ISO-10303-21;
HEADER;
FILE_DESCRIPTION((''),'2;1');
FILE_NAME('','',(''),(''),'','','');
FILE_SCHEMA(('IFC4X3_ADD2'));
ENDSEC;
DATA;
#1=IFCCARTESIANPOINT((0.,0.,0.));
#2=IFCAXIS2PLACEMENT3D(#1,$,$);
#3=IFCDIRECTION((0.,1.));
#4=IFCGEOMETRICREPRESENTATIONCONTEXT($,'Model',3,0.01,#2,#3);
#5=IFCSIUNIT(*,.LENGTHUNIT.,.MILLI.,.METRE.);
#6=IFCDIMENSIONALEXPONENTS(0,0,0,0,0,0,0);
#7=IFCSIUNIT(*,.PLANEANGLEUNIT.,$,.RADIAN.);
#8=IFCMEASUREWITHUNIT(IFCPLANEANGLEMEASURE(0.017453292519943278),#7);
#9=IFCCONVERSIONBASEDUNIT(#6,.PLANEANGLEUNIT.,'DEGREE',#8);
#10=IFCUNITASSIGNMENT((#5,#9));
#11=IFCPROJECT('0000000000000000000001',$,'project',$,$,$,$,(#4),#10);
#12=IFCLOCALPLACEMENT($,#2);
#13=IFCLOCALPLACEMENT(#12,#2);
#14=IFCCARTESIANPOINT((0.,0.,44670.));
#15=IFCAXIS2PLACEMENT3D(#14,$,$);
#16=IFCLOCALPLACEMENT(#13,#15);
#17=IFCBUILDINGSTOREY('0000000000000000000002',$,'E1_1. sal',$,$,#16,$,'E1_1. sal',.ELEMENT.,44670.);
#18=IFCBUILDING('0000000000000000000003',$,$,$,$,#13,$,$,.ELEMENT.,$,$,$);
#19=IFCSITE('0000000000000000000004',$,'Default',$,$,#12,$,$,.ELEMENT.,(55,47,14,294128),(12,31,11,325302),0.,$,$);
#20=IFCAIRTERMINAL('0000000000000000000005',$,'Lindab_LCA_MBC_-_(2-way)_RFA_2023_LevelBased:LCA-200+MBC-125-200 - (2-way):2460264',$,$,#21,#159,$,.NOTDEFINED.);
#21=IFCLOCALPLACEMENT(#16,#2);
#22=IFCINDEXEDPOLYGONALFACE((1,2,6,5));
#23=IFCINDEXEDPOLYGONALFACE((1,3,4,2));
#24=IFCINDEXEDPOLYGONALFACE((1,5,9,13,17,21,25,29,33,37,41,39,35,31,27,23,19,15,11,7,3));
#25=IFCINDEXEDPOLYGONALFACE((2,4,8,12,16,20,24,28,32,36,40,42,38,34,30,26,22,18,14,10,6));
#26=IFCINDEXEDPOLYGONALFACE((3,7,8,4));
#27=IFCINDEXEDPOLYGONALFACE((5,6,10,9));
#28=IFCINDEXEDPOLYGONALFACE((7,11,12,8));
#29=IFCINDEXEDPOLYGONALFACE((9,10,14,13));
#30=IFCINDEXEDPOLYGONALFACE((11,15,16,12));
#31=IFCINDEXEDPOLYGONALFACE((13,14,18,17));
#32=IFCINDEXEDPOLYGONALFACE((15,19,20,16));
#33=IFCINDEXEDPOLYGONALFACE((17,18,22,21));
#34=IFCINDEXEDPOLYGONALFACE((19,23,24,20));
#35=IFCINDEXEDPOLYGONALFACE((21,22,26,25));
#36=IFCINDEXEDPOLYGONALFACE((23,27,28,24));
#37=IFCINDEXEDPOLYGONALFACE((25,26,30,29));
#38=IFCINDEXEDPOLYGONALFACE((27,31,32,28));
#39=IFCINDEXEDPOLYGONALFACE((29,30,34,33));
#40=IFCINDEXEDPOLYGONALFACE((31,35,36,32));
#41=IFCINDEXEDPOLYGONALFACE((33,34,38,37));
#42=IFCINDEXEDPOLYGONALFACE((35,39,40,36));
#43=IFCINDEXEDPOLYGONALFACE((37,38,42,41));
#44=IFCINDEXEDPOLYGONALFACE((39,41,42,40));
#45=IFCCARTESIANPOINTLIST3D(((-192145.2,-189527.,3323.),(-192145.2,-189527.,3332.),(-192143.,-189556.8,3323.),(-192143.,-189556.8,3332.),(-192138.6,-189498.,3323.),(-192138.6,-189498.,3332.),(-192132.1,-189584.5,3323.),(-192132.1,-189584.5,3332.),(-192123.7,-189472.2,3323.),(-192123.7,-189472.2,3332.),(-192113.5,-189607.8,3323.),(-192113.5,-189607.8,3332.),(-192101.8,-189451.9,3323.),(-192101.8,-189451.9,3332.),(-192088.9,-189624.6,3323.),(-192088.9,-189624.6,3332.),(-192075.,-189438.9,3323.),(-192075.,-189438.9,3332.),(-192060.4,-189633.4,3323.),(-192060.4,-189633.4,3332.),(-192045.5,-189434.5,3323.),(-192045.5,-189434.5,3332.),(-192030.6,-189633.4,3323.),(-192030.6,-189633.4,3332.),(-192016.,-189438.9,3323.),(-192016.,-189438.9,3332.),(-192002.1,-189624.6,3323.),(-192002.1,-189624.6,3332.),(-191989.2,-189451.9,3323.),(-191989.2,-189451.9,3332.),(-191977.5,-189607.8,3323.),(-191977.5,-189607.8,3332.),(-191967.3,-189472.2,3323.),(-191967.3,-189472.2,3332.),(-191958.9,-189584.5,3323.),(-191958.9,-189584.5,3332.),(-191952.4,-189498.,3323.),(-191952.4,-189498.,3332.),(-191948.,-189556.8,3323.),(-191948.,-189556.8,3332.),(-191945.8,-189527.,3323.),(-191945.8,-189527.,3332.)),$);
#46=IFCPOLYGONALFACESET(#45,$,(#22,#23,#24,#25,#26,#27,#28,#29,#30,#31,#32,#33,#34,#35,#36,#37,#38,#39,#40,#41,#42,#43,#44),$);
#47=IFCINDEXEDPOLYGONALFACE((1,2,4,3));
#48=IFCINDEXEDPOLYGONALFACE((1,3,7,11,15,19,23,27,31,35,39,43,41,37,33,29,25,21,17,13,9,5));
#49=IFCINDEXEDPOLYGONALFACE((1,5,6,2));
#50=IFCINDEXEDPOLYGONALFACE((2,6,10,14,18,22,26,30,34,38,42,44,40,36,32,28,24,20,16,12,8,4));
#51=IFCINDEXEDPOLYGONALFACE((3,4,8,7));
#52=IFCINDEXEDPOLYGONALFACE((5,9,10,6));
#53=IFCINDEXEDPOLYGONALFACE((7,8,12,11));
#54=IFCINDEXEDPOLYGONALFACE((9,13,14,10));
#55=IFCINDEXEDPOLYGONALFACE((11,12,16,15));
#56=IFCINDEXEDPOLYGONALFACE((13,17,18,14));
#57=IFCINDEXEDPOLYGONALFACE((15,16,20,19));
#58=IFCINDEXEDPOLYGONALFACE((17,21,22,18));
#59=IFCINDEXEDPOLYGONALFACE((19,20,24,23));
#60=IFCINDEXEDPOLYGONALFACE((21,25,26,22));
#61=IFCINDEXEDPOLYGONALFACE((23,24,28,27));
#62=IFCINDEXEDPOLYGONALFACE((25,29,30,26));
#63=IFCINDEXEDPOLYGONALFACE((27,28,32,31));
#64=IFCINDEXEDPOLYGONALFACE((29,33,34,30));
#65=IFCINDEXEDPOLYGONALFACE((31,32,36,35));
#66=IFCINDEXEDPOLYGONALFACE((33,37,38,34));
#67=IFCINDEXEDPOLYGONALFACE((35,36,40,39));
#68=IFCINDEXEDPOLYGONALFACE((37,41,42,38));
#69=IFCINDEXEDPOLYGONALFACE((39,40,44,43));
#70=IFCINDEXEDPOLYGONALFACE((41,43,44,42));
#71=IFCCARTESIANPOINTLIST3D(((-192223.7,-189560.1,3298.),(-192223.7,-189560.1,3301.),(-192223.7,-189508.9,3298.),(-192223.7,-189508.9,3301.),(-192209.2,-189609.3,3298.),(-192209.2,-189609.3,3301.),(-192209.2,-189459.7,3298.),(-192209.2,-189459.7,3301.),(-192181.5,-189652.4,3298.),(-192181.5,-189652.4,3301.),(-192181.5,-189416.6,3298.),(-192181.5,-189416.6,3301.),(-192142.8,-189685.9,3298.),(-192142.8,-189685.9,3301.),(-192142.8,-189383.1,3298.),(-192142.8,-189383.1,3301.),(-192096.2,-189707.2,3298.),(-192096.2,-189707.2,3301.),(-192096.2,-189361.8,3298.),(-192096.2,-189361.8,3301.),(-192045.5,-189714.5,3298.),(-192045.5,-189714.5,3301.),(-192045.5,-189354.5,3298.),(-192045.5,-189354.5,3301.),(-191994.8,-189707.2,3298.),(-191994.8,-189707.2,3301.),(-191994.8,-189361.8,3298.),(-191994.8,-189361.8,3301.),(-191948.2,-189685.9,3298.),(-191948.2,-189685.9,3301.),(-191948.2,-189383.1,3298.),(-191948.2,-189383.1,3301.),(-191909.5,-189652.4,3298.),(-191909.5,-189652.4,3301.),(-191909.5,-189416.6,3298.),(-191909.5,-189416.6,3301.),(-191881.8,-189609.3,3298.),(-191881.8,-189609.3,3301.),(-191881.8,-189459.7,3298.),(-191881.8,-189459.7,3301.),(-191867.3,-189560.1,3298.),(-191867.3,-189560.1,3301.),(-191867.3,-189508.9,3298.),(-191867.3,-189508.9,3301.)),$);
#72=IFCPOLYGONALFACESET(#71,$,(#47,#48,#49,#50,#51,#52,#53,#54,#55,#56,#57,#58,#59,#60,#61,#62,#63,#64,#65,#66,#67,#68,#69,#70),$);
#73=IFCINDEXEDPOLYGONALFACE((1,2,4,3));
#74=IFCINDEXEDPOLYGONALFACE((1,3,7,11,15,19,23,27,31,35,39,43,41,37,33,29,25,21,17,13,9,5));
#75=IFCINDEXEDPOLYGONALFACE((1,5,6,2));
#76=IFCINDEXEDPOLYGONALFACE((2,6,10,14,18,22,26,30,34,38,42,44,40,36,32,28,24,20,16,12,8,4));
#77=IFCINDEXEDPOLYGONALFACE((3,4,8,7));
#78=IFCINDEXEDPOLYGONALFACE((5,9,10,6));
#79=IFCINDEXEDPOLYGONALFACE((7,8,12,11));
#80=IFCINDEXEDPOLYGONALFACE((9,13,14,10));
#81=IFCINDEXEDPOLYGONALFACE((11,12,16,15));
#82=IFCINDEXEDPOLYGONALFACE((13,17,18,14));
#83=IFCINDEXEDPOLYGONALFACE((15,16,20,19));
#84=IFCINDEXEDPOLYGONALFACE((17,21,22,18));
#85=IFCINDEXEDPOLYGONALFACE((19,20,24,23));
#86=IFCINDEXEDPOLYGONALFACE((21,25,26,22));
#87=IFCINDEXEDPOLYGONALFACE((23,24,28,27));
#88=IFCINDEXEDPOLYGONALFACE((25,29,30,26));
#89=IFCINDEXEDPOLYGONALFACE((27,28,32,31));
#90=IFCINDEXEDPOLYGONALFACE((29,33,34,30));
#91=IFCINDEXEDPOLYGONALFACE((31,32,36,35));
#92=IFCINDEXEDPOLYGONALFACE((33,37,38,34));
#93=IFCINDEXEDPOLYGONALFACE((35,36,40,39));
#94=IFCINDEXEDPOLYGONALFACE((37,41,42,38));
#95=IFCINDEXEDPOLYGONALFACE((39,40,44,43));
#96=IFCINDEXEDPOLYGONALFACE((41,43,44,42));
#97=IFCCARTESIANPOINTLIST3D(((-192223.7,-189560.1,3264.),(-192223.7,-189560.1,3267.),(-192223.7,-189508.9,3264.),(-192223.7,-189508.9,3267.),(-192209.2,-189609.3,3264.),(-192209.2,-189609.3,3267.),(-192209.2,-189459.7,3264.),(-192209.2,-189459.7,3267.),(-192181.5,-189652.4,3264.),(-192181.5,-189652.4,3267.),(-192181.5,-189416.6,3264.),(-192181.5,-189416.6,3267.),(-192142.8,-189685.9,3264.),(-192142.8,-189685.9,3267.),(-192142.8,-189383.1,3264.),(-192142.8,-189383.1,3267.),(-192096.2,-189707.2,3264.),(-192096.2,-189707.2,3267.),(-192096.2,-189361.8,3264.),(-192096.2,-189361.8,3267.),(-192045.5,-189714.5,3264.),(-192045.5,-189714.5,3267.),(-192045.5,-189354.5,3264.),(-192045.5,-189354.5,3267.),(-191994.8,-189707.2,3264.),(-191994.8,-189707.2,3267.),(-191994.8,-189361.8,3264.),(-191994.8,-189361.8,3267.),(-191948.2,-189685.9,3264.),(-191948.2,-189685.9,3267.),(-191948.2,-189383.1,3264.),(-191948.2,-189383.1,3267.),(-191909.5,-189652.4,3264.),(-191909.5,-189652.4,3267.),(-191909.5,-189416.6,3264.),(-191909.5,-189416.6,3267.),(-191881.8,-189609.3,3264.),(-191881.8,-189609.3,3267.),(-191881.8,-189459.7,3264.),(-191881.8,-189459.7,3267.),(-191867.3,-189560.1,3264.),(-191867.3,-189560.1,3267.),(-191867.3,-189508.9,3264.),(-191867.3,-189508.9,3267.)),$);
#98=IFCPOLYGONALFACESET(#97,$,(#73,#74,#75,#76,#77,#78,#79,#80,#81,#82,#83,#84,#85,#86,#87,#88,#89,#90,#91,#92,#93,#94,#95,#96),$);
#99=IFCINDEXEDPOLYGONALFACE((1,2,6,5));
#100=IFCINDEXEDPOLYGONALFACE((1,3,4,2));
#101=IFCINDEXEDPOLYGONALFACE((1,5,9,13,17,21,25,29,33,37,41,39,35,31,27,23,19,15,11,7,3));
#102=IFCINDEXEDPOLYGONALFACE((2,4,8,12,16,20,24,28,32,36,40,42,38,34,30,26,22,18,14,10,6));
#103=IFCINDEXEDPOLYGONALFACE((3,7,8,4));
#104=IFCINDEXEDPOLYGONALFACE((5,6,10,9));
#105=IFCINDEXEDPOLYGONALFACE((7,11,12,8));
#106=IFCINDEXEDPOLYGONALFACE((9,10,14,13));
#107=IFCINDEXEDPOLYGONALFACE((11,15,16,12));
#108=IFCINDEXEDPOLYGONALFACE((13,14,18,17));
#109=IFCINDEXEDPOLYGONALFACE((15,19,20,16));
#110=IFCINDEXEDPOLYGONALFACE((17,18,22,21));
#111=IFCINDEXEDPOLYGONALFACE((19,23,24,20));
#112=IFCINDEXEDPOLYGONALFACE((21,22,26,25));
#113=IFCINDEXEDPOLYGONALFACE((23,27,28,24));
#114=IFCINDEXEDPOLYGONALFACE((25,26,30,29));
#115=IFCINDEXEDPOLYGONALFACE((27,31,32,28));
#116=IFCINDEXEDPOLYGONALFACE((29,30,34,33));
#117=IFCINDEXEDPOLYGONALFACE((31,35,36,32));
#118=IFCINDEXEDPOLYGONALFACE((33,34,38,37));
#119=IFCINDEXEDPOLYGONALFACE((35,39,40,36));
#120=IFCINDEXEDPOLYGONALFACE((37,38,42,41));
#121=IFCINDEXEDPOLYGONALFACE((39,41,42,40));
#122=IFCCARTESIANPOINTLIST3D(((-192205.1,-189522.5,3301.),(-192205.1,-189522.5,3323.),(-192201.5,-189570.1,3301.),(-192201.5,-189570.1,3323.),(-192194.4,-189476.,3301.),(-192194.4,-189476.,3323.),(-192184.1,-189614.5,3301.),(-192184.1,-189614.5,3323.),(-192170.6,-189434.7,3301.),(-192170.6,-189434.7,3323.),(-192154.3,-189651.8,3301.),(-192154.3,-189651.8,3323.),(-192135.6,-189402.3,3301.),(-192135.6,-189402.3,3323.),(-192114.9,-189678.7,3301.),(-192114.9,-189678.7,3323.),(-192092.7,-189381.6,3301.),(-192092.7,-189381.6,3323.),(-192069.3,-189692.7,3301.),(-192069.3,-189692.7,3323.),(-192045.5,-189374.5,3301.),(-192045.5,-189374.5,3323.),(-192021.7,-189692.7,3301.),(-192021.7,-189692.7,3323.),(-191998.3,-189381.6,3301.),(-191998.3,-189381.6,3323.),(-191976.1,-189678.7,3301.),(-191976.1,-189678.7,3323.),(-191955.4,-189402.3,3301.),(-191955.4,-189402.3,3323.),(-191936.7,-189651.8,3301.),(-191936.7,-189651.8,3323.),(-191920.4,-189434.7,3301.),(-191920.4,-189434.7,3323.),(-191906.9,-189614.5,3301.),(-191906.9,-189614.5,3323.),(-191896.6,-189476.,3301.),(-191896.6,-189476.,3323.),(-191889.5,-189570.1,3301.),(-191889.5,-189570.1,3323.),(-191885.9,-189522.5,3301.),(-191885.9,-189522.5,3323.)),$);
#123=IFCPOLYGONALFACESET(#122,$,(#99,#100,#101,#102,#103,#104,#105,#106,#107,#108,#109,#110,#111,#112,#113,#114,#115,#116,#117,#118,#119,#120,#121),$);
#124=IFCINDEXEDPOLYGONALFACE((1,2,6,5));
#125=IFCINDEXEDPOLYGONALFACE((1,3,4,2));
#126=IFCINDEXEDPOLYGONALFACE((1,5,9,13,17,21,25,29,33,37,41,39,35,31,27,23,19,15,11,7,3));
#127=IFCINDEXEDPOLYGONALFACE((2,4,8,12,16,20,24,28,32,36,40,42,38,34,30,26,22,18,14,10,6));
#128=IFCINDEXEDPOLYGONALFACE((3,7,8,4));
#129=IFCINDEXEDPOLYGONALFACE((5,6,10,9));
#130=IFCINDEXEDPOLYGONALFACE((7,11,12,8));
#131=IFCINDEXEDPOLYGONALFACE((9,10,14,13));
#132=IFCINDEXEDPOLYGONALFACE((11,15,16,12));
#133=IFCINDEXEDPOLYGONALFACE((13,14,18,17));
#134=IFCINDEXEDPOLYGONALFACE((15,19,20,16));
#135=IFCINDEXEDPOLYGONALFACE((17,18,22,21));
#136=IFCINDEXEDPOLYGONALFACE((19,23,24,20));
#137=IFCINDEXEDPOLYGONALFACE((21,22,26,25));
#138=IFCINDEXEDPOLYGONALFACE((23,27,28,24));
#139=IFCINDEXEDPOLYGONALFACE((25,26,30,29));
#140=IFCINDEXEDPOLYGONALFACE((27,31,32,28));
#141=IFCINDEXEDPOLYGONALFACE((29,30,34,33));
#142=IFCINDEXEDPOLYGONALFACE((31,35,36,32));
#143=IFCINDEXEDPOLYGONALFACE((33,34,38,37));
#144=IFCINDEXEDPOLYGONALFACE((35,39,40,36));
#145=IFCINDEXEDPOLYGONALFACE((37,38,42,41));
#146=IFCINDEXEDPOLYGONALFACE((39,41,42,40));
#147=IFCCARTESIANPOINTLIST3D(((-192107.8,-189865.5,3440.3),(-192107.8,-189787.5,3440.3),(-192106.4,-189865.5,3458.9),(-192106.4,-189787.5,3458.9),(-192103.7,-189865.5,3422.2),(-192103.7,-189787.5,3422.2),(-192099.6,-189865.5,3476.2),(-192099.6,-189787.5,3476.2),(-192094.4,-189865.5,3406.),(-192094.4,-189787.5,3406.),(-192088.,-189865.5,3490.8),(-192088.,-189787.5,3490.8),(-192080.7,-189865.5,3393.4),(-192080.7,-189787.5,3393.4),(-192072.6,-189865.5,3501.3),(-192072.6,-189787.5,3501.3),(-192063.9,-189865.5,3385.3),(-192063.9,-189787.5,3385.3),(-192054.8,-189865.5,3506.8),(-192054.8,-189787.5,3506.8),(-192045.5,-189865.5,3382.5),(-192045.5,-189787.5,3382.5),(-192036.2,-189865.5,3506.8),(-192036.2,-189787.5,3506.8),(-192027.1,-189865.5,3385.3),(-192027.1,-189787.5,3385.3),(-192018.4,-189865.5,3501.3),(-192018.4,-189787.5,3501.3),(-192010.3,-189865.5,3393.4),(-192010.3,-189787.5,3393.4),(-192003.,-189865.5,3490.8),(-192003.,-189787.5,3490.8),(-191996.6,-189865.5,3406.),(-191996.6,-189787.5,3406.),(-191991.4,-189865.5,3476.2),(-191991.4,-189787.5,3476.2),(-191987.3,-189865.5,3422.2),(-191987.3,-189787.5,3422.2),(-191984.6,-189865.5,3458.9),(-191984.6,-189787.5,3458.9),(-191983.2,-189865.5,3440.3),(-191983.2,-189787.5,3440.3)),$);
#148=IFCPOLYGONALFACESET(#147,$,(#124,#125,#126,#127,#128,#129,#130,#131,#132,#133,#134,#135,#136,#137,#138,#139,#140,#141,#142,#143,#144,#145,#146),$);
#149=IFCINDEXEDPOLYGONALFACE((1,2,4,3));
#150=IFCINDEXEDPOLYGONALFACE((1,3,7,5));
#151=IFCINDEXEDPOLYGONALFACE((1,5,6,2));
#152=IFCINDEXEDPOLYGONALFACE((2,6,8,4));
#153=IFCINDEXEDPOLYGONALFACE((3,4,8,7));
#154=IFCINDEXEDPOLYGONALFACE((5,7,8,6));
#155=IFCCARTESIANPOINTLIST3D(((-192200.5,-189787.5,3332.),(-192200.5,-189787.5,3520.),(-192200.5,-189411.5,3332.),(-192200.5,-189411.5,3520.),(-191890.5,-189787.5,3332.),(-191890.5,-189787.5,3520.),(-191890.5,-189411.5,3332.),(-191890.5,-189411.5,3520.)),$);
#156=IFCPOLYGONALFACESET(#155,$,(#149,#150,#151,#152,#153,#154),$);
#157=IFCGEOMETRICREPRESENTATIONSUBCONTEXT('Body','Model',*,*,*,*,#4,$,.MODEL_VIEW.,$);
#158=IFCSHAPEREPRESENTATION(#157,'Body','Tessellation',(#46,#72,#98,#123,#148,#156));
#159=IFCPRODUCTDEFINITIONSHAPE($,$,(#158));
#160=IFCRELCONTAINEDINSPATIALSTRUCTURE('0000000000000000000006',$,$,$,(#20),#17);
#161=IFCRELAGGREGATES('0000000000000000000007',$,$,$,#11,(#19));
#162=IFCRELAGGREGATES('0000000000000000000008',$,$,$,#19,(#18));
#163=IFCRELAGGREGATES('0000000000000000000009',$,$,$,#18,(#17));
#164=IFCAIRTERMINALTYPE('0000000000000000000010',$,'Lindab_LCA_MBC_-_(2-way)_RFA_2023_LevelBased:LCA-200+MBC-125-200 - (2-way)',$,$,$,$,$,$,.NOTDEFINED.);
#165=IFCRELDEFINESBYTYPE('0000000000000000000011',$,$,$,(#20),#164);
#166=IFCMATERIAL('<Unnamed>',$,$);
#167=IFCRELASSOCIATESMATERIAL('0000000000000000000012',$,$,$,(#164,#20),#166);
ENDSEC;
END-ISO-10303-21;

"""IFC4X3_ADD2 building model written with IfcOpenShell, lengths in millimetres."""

from ifc_helpers import new_model, entity, si_unit, converted_unit, direction, frame, frame_2d, origin, origin_2d_with_axis, place, context, subcontext, project, spatial, rectangle, circle, extrude, source, transform, mapped, material, type_object, type_shapes, element, save


model = new_model("IFC4X3_ADD2")

# Units and contexts
model_context = context("Model", 3, precision=0.01, world=origin(), true_north=direction((0.0, 1.0)))
body_context = subcontext(model_context, "Body", "Model", "MODEL_VIEW")
ifc_project = project(units=[si_unit("LENGTHUNIT", "METRE", prefix="MILLI"), converted_unit("PLANEANGLEUNIT", "DEGREE", entity("IfcPlaneAngleMeasure", 0.017453292519943278), si_unit("PLANEANGLEUNIT", "RADIAN"), dimensions=[0, 0, 0, 0, 0, 0, 0])], contexts=[model_context])

# Site, building, storey
site_placement = place(None, origin())
site = spatial("IfcSite", under=ifc_project, at=site_placement, Name="Default", CompositionType="ELEMENT", RefLatitude=(55, 47, 14, 294128), RefLongitude=(12, 31, 11, 325302), RefElevation=0.0)
building_placement = place(site_placement, origin())
building = spatial("IfcBuilding", under=site, at=building_placement, CompositionType="ELEMENT")
storey_placement = place(building_placement, frame((0.0, 0.0, 44670.0)))
storey = spatial("IfcBuildingStorey", under=building, at=storey_placement, Name="E1_1. sal", LongName="E1_1. sal", CompositionType="ELEMENT", Elevation=44670.0)

# Air terminal
ifc_material_1 = material(Name="<Unnamed>")
air_terminal_type = type_object("IfcAirTerminalType", Name="Lindab_LCA_MBC_-_(2-way)_RFA_2023_LevelBased:LCA-200+MBC-125-200 - (2-way)", PredefinedType="NOTDEFINED", material=ifc_material_1)
shared_shape_1 = source(origin(), body_context, "Body", "SweptSolid", [
    extrude(circle(Radius=100.0, at=frame_2d((0.0, 0.0), x_axis=(1.0, 0.0))), frame((0.0, 0.0, 22.0)), (0.0, 0.0, 1.0), 9.0),
    extrude(circle(Radius=180.0, at=frame_2d((0.0, 0.0), x_axis=(1.0, 0.0))), frame((0.0, 0.0, -3.0)), (0.0, 0.0, 1.0), 3.0),
    extrude(circle(Radius=180.0, at=frame_2d((0.0, 0.0), x_axis=(1.0, 0.0))), frame((0.0, 0.0, -37.0)), (0.0, 0.0, 1.0), 3.0),
    extrude(circle(Radius=160.0, at=frame_2d((0.0, 0.0), x_axis=(1.0, 0.0))), origin(), (0.0, 0.0, 1.0), 22.0),
    extrude(circle(Radius=62.5, at=frame_2d((0.0, 0.0), x_axis=(1.0, 0.0))), frame((-331.0, 0.0, 144.0), z_axis=(1.0, 0.0, 0.0), x_axis=(0.0, 0.0, -1.0)), (0.0, 0.0, 1.0), 78.0),
    extrude(rectangle(XDim=310.0, YDim=376.0, at=origin_2d_with_axis()), frame((-65.0, 0.0, 31.0), z_axis=(0.0, 0.0, 1.0), x_axis=(0.0, -1.0, 0.0)), (0.0, 0.0, 1.0), 188.0),
])
type_shapes(air_terminal_type, [shared_shape_1])
for number, where, z_axis, x_axis, name in (
    (1, (-192045.5, -189534.5, 3301.0), (0.0, 0.0, 1.0), (0.0, 1.0, 0.0), "Lindab_LCA_MBC_-_(2-way)_RFA_2023_LevelBased:LCA-200+MBC-125-200 - (2-way):2460264"),
):
    element("IfcAirTerminal", number, at=place(storey_placement, frame(where, z_axis=z_axis, x_axis=x_axis)), inside=storey, type_object=air_terminal_type, material=ifc_material_1, Name=name, PredefinedType="NOTDEFINED", context=body_context, shape_type="MappedRepresentation", body=[
        mapped(shared_shape_1, transform((0.0, 0.0, 0.0), scale=1.0)),
    ])

save(model, "model.ifc")
